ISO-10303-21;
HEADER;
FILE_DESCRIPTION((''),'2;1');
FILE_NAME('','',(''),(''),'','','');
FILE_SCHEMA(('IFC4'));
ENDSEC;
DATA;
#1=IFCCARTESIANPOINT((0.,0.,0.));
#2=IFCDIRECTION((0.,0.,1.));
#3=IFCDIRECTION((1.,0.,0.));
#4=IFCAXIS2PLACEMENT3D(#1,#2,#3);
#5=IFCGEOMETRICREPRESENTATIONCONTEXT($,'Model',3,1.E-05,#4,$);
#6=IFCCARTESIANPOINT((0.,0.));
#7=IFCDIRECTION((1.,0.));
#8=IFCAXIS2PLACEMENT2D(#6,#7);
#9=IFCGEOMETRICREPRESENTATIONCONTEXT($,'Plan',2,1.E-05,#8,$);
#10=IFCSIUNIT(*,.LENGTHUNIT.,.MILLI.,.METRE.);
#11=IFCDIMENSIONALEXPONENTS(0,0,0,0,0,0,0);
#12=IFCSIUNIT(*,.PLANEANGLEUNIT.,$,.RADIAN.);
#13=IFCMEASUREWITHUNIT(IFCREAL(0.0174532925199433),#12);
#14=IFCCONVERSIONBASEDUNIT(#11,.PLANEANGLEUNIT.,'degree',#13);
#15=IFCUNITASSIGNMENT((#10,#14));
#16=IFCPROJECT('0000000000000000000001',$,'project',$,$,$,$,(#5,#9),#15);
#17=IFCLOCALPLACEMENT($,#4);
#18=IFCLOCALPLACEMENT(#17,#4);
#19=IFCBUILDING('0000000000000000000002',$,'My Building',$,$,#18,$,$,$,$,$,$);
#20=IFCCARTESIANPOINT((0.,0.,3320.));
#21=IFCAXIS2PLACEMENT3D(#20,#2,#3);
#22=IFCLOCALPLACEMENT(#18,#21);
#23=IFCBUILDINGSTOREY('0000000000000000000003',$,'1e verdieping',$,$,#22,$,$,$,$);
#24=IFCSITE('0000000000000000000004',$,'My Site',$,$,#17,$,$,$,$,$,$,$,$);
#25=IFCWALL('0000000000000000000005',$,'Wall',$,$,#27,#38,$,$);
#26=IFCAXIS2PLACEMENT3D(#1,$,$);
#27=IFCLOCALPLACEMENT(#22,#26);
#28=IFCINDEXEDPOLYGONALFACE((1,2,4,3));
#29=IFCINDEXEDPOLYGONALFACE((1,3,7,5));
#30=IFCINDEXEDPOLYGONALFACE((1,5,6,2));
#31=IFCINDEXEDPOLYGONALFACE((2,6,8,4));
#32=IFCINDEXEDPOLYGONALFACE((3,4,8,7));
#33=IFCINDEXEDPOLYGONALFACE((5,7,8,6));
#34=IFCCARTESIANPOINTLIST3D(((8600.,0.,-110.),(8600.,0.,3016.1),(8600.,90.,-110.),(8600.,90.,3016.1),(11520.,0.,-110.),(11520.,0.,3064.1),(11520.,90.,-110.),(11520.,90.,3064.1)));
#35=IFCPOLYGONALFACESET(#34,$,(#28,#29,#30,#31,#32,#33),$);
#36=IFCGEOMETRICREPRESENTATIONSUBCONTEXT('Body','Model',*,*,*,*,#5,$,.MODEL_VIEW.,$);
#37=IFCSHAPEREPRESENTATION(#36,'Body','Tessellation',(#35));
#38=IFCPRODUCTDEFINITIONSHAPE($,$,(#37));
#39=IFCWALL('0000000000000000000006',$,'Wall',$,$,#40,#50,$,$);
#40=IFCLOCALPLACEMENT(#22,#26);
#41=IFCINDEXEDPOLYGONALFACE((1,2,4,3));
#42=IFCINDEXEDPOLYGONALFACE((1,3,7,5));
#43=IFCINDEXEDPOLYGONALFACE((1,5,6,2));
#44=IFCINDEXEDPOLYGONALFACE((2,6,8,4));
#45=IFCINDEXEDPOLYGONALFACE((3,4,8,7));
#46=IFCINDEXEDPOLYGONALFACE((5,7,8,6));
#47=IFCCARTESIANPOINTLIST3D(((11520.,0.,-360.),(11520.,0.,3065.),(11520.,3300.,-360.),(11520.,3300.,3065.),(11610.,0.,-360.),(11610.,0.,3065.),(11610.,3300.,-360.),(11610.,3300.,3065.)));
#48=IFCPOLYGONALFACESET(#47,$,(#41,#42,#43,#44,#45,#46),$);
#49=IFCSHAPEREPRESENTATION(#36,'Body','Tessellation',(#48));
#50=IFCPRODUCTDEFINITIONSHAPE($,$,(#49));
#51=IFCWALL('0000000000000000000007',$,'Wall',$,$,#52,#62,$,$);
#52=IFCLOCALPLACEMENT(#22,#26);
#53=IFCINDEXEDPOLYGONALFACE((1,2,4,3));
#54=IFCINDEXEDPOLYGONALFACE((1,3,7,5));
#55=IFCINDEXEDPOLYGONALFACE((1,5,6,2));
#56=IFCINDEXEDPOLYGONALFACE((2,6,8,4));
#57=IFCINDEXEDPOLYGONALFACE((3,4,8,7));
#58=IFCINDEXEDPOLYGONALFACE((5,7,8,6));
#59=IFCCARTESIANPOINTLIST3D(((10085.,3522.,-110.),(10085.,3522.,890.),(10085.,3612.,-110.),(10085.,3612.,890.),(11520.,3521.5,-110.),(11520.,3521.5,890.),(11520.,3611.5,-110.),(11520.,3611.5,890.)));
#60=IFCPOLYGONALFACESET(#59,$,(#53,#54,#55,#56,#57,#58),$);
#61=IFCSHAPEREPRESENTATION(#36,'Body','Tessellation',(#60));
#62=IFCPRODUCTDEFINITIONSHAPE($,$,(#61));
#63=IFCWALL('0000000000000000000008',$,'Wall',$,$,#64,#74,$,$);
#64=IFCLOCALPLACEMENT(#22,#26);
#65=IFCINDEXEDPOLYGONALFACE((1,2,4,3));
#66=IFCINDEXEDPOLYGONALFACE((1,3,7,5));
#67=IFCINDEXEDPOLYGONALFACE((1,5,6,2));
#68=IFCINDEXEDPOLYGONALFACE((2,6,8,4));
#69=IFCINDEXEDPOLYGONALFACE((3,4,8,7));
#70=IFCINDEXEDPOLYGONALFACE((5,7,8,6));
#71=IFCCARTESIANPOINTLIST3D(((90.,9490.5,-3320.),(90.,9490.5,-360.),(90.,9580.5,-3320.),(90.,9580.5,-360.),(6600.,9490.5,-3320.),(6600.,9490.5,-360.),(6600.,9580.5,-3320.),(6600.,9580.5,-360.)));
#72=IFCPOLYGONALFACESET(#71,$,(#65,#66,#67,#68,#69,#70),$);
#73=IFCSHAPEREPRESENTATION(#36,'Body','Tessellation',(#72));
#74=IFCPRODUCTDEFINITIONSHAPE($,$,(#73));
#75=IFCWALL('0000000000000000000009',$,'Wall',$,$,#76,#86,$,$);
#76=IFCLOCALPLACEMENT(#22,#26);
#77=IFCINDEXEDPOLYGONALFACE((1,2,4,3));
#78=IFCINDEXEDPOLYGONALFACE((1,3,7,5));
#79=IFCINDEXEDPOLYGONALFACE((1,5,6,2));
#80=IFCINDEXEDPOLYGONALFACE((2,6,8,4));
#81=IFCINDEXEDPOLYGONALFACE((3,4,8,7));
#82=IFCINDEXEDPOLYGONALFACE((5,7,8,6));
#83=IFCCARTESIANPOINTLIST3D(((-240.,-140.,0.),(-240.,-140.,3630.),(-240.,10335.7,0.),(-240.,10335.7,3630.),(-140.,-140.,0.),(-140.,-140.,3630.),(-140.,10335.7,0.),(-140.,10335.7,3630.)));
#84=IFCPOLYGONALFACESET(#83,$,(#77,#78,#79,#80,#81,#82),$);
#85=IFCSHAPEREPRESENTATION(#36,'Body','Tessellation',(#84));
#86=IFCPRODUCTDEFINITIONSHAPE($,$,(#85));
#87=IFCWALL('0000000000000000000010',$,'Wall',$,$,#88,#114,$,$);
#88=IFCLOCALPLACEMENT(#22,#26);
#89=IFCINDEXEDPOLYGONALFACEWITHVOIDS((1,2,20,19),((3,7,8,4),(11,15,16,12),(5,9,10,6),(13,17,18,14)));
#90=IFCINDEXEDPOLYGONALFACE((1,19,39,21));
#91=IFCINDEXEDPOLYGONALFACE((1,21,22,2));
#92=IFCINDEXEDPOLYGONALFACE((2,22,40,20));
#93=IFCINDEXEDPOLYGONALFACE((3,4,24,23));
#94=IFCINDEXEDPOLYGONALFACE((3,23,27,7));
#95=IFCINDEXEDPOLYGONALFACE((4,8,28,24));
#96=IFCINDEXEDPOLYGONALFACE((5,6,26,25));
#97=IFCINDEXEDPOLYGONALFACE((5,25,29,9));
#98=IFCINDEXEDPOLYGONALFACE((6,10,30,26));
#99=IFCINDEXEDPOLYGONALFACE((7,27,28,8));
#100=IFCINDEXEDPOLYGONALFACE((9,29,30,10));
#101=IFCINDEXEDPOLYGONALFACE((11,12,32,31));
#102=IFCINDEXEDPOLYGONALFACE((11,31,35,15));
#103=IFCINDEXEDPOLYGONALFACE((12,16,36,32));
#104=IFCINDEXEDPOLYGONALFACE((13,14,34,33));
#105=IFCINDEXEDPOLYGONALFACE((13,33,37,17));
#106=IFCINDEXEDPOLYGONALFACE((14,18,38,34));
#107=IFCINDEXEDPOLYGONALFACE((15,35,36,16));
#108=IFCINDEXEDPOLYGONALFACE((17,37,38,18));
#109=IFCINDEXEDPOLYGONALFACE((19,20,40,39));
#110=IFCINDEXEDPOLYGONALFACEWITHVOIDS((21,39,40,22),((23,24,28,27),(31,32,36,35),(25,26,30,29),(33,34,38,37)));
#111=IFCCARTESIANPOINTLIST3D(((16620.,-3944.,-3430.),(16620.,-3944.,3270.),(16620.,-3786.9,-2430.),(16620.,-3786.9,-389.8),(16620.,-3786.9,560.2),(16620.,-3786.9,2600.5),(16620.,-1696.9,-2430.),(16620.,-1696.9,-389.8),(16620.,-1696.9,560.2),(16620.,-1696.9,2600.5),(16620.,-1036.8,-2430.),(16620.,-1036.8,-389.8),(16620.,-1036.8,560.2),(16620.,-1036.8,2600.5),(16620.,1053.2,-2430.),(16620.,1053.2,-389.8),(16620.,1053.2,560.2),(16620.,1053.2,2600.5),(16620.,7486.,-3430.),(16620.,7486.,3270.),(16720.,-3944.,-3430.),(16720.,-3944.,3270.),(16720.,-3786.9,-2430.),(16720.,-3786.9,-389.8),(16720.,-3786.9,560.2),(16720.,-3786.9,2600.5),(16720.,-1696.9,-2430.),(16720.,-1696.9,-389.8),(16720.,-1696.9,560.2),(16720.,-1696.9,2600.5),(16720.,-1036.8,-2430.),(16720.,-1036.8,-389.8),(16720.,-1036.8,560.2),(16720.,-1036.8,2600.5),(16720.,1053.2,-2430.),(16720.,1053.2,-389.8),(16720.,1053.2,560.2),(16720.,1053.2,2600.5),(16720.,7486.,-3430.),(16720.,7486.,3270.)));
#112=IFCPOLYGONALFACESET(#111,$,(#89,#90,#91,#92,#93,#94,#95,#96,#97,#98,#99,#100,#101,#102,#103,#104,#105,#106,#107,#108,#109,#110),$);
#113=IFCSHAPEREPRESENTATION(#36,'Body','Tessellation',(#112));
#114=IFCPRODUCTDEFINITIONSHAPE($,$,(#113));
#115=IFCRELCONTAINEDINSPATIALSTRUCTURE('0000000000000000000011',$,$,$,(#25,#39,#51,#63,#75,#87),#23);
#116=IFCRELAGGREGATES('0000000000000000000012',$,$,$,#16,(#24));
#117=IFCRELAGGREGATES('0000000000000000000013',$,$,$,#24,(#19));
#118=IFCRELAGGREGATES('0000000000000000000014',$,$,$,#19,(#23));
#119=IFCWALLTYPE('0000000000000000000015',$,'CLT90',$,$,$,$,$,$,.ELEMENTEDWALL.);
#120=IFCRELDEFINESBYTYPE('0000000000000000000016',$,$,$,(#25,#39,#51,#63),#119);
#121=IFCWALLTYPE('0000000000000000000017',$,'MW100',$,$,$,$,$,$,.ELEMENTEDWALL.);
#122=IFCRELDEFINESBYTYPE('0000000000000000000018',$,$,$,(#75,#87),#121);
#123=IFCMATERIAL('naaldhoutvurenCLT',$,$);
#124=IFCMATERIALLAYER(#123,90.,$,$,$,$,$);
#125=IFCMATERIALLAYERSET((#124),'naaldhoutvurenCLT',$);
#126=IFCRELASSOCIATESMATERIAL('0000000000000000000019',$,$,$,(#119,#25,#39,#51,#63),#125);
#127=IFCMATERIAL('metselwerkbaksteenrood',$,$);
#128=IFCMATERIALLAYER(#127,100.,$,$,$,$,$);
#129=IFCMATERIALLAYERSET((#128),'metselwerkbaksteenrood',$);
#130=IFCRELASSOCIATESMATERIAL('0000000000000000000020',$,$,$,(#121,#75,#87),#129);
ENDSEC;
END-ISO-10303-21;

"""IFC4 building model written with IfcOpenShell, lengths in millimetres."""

from ifc_helpers import new_model, entity, si_unit, converted_unit, frame, origin_with_axes, origin_2d_with_axis, place, context, subcontext, project, spatial, line, indexed_curve, outline, extrude, clip, halfspace, source, transform, mapped, material, layer, layer_set, layer_usage, type_object, element, save


model = new_model("IFC4")

# Units and contexts
model_context = context("Model", 3, precision=1e-05, world=origin_with_axes())
plan_context = context("Plan", 2, precision=1e-05, world=origin_2d_with_axis())
body_context = subcontext(model_context, "Body", "Model", "MODEL_VIEW")
ifc_project = project(units=[si_unit("LENGTHUNIT", "METRE", prefix="MILLI"), converted_unit("PLANEANGLEUNIT", "degree", entity("IfcReal", 0.0174532925199433), si_unit("PLANEANGLEUNIT", "RADIAN"), dimensions=[0, 0, 0, 0, 0, 0, 0])], contexts=[model_context, plan_context])

# Site, building, storey
site_placement = place(None, origin_with_axes())
site = spatial("IfcSite", under=ifc_project, at=site_placement, Name="My Site")
building_placement = place(site_placement, origin_with_axes())
building = spatial("IfcBuilding", under=site, at=building_placement, Name="My Building")
storey_placement = place(building_placement, frame((0.0, 0.0, 3320.0), z_axis=(0.0, 0.0, 1.0), x_axis=(1.0, 0.0, 0.0)))
storey = spatial("IfcBuildingStorey", under=building, at=storey_placement, Name="1e verdieping")

# Shared definitions
ifc_material_1 = material(Name="naaldhoutvurenCLT")

# Walls
ifc_layer_1 = layer(ifc_material_1, 90.0)
ifc_layer_set_1 = layer_set([ifc_layer_1], Name="naaldhoutvurenCLT")
wall_type_1 = type_object("IfcWallType", Name="CLT90", PredefinedType="ELEMENTEDWALL", material=ifc_layer_set_1)
ifc_layer_usage_1 = layer_usage(ifc_layer_set_1, "AXIS2", "POSITIVE", 0.0)
wall_1_placement = place(storey_placement, frame((8600.0, 0.0, -110.0), z_axis=(0.0, 0.0, 1.0), x_axis=(1.0, 0.0, 0.0)))
element("IfcWall", 1, at=wall_1_placement, inside=storey, type_object=wall_type_1, material=ifc_layer_usage_1, Name="Wall", context=body_context, shape_type="Clipping", body=[
    clip(extrude(outline(indexed_curve([(0.0, 0.0), (0.0, 90.0), (2920.0, 90.0), (2920.0, 0.0), (0.0, 0.0)], self_intersect=False)), origin_with_axes(), (0.0, 0.0, 1.0), 6384.1), halfspace(frame((2920.0, 0.0, 3174.1), z_axis=(-0.016405, 0.0, 0.999865), x_axis=(0.0, 1.0, 0.0)), False)),
])
ifc_layer_usage_2 = layer_usage(ifc_layer_set_1, "AXIS2", "POSITIVE", 0.0)
wall_2_placement = place(storey_placement, frame((11520.0, 3300.0, -360.0), z_axis=(0.0, 0.0, 1.0), x_axis=(0.0, -1.0, 0.0)))
element("IfcWall", 2, at=wall_2_placement, inside=storey, type_object=wall_type_1, material=ifc_layer_usage_2, Name="Wall", context=body_context, shape_type="SweptSolid", body=[
    extrude(outline(indexed_curve([(0.0, 0.0), (0.0, 90.0), (3300.0, 90.0), (3300.0, 0.0), (0.0, 0.0)], self_intersect=False)), origin_with_axes(), (0.0, 0.0, 1.0), 3425.0),
])
ifc_layer_usage_3 = layer_usage(ifc_layer_set_1, "AXIS2", "POSITIVE", 0.0)
wall_3_placement = place(storey_placement, frame((10085.0, 3522.0, -110.0), z_axis=(0.0, 0.0, 1.0), x_axis=(1.0, -0.00033, 0.0)))
element("IfcWall", 3, at=wall_3_placement, inside=storey, type_object=wall_type_1, material=ifc_layer_usage_3, Name="Wall", context=body_context, shape_type="SweptSolid", body=[
    extrude(outline(indexed_curve([(0.0, 0.0), (0.0, 90.0), (1435.0, 90.0), (1435.0, 0.0), (0.0, 0.0)], self_intersect=False)), origin_with_axes(), (0.0, 0.0, 1.0), 1000.0),
])
ifc_layer_usage_4 = layer_usage(ifc_layer_set_1, "AXIS2", "POSITIVE", 0.0)
wall_4_placement = place(storey_placement, frame((90.0, 9490.5, -3320.0), z_axis=(0.0, 0.0, 1.0), x_axis=(1.0, 0.0, 0.0)))
element("IfcWall", 4, at=wall_4_placement, inside=storey, type_object=wall_type_1, material=ifc_layer_usage_4, Name="Wall", context=body_context, shape_type="SweptSolid", body=[
    extrude(outline(indexed_curve([(0.0, 0.0), (0.0, 90.0), (6510.0, 90.0), (6510.0, 0.0), (0.0, 0.0)], self_intersect=False)), origin_with_axes(), (0.0, 0.0, 1.0), 2960.0),
])

# Shared definitions
ifc_material_2 = material(Name="metselwerkbaksteenrood")
ifc_layer_2 = layer(ifc_material_2, 100.0)
ifc_layer_set_2 = layer_set([ifc_layer_2], Name="metselwerkbaksteenrood")
wall_type_2 = type_object("IfcWallType", Name="MW100", PredefinedType="ELEMENTEDWALL", material=ifc_layer_set_2)

# Wall
ifc_layer_usage_5 = layer_usage(ifc_layer_set_2, "AXIS2", "POSITIVE", 0.0)
wall_5_placement = place(storey_placement, frame((-240.0, 10335.7, 0.0), z_axis=(0.0, 0.0, 1.0), x_axis=(0.0, -1.0, 0.0)))
element("IfcWall", 5, at=wall_5_placement, inside=storey, type_object=wall_type_2, material=ifc_layer_usage_5, Name="Wall", context=body_context, shape_type="SweptSolid", body=[
    extrude(outline(indexed_curve([(0.0, 0.0), (0.0, 100.0), (10475.7, 100.0), (10475.7, 0.0), (0.0, 0.0)], self_intersect=False)), origin_with_axes(), (0.0, 0.0, 1.0), 3630.0),
])

# Wall, openings
ifc_layer_usage_6 = layer_usage(ifc_layer_set_2, "AXIS2", "POSITIVE", 0.0)
wall_6_placement = place(storey_placement, frame((16620.0, 7486.0, -3430.0), z_axis=(0.0, 0.0, 1.0), x_axis=(0.0, -1.0, 0.0)))
wall_6 = element("IfcWall", 6, at=wall_6_placement, inside=storey, type_object=wall_type_2, material=ifc_layer_usage_6, Name="Wall", context=body_context, shape_type="SweptSolid", body=[
    extrude(outline(indexed_curve([(0.0, 0.0), (0.0, 100.0), (11430.0, 100.0), (11430.0, 0.0), (0.0, 0.0)], self_intersect=False)), origin_with_axes(), (0.0, 0.0, 1.0), 6700.0),
])
shared_shape_1 = source(origin_with_axes(), body_context, "Body", "SweptSolid", [
    extrude(outline(indexed_curve([(0.0, 0.0), (2090.0, 0.0), (2090.0, 2040.2), (0.0, 2040.2)], segments=[line(1, 2, 3, 4, 1)])), frame((0.1, -600.0, 0.0), z_axis=(0.0, -1.0, 0.0), x_axis=(1.0, 0.0, 0.0)), (0.0, 0.0, -1.0), 1200.0),
])
opening_1_placement = place(wall_6_placement, frame((9182.8, -169.2, 3990.2), z_axis=(0.0, 0.0, 1.0), x_axis=(1.0, 0.0, 0.0)))
element("IfcOpeningElement", 7, at=opening_1_placement, cuts=wall_6, PredefinedType="OPENING", context=body_context, shape_type="MappedRepresentation", body=[
    mapped(shared_shape_1, transform((0.0, 0.0, 0.0), x_axis=(1.0, 0.0, 0.0), y_axis=(0.0, 1.0, 0.0), z_axis=(0.0, 0.0, 1.0), scale=1.0)),
])
opening_2_placement = place(wall_6_placement, frame((8522.9, 169.2, 1000.0), z_axis=(0.0, 0.0, 1.0), x_axis=(-1.0, 0.0, 0.0)))
element("IfcOpeningElement", 8, at=opening_2_placement, cuts=wall_6, PredefinedType="OPENING", context=body_context, shape_type="MappedRepresentation", body=[
    mapped(shared_shape_1, transform((0.0, 0.0, 0.0), x_axis=(1.0, 0.0, 0.0), y_axis=(0.0, 1.0, 0.0), z_axis=(0.0, 0.0, 1.0), scale=1.0)),
])
opening_3_placement = place(wall_6_placement, frame((6432.7, 0.0, 3990.2), z_axis=(0.0, 0.0, 1.0), x_axis=(1.0, 0.0, 0.0)))
element("IfcOpeningElement", 9, at=opening_3_placement, cuts=wall_6, PredefinedType="OPENING", context=body_context, shape_type="MappedRepresentation", body=[
    mapped(shared_shape_1, transform((0.0, 0.0, 0.0), x_axis=(1.0, 0.0, 0.0), y_axis=(0.0, 1.0, 0.0), z_axis=(0.0, 0.0, 1.0), scale=1.0)),
])
opening_4_placement = place(wall_6_placement, frame((11273.0, 169.2, 1000.0), z_axis=(0.0, 0.0, 1.0), x_axis=(-1.0, 0.0, 0.0)))
element("IfcOpeningElement", 10, at=opening_4_placement, cuts=wall_6, PredefinedType="OPENING", context=body_context, shape_type="MappedRepresentation", body=[
    mapped(shared_shape_1, transform((0.0, 0.0, 0.0), x_axis=(1.0, 0.0, 0.0), y_axis=(0.0, 1.0, 0.0), z_axis=(0.0, 0.0, 1.0), scale=1.0)),
])

save(model, "model.ifc")
